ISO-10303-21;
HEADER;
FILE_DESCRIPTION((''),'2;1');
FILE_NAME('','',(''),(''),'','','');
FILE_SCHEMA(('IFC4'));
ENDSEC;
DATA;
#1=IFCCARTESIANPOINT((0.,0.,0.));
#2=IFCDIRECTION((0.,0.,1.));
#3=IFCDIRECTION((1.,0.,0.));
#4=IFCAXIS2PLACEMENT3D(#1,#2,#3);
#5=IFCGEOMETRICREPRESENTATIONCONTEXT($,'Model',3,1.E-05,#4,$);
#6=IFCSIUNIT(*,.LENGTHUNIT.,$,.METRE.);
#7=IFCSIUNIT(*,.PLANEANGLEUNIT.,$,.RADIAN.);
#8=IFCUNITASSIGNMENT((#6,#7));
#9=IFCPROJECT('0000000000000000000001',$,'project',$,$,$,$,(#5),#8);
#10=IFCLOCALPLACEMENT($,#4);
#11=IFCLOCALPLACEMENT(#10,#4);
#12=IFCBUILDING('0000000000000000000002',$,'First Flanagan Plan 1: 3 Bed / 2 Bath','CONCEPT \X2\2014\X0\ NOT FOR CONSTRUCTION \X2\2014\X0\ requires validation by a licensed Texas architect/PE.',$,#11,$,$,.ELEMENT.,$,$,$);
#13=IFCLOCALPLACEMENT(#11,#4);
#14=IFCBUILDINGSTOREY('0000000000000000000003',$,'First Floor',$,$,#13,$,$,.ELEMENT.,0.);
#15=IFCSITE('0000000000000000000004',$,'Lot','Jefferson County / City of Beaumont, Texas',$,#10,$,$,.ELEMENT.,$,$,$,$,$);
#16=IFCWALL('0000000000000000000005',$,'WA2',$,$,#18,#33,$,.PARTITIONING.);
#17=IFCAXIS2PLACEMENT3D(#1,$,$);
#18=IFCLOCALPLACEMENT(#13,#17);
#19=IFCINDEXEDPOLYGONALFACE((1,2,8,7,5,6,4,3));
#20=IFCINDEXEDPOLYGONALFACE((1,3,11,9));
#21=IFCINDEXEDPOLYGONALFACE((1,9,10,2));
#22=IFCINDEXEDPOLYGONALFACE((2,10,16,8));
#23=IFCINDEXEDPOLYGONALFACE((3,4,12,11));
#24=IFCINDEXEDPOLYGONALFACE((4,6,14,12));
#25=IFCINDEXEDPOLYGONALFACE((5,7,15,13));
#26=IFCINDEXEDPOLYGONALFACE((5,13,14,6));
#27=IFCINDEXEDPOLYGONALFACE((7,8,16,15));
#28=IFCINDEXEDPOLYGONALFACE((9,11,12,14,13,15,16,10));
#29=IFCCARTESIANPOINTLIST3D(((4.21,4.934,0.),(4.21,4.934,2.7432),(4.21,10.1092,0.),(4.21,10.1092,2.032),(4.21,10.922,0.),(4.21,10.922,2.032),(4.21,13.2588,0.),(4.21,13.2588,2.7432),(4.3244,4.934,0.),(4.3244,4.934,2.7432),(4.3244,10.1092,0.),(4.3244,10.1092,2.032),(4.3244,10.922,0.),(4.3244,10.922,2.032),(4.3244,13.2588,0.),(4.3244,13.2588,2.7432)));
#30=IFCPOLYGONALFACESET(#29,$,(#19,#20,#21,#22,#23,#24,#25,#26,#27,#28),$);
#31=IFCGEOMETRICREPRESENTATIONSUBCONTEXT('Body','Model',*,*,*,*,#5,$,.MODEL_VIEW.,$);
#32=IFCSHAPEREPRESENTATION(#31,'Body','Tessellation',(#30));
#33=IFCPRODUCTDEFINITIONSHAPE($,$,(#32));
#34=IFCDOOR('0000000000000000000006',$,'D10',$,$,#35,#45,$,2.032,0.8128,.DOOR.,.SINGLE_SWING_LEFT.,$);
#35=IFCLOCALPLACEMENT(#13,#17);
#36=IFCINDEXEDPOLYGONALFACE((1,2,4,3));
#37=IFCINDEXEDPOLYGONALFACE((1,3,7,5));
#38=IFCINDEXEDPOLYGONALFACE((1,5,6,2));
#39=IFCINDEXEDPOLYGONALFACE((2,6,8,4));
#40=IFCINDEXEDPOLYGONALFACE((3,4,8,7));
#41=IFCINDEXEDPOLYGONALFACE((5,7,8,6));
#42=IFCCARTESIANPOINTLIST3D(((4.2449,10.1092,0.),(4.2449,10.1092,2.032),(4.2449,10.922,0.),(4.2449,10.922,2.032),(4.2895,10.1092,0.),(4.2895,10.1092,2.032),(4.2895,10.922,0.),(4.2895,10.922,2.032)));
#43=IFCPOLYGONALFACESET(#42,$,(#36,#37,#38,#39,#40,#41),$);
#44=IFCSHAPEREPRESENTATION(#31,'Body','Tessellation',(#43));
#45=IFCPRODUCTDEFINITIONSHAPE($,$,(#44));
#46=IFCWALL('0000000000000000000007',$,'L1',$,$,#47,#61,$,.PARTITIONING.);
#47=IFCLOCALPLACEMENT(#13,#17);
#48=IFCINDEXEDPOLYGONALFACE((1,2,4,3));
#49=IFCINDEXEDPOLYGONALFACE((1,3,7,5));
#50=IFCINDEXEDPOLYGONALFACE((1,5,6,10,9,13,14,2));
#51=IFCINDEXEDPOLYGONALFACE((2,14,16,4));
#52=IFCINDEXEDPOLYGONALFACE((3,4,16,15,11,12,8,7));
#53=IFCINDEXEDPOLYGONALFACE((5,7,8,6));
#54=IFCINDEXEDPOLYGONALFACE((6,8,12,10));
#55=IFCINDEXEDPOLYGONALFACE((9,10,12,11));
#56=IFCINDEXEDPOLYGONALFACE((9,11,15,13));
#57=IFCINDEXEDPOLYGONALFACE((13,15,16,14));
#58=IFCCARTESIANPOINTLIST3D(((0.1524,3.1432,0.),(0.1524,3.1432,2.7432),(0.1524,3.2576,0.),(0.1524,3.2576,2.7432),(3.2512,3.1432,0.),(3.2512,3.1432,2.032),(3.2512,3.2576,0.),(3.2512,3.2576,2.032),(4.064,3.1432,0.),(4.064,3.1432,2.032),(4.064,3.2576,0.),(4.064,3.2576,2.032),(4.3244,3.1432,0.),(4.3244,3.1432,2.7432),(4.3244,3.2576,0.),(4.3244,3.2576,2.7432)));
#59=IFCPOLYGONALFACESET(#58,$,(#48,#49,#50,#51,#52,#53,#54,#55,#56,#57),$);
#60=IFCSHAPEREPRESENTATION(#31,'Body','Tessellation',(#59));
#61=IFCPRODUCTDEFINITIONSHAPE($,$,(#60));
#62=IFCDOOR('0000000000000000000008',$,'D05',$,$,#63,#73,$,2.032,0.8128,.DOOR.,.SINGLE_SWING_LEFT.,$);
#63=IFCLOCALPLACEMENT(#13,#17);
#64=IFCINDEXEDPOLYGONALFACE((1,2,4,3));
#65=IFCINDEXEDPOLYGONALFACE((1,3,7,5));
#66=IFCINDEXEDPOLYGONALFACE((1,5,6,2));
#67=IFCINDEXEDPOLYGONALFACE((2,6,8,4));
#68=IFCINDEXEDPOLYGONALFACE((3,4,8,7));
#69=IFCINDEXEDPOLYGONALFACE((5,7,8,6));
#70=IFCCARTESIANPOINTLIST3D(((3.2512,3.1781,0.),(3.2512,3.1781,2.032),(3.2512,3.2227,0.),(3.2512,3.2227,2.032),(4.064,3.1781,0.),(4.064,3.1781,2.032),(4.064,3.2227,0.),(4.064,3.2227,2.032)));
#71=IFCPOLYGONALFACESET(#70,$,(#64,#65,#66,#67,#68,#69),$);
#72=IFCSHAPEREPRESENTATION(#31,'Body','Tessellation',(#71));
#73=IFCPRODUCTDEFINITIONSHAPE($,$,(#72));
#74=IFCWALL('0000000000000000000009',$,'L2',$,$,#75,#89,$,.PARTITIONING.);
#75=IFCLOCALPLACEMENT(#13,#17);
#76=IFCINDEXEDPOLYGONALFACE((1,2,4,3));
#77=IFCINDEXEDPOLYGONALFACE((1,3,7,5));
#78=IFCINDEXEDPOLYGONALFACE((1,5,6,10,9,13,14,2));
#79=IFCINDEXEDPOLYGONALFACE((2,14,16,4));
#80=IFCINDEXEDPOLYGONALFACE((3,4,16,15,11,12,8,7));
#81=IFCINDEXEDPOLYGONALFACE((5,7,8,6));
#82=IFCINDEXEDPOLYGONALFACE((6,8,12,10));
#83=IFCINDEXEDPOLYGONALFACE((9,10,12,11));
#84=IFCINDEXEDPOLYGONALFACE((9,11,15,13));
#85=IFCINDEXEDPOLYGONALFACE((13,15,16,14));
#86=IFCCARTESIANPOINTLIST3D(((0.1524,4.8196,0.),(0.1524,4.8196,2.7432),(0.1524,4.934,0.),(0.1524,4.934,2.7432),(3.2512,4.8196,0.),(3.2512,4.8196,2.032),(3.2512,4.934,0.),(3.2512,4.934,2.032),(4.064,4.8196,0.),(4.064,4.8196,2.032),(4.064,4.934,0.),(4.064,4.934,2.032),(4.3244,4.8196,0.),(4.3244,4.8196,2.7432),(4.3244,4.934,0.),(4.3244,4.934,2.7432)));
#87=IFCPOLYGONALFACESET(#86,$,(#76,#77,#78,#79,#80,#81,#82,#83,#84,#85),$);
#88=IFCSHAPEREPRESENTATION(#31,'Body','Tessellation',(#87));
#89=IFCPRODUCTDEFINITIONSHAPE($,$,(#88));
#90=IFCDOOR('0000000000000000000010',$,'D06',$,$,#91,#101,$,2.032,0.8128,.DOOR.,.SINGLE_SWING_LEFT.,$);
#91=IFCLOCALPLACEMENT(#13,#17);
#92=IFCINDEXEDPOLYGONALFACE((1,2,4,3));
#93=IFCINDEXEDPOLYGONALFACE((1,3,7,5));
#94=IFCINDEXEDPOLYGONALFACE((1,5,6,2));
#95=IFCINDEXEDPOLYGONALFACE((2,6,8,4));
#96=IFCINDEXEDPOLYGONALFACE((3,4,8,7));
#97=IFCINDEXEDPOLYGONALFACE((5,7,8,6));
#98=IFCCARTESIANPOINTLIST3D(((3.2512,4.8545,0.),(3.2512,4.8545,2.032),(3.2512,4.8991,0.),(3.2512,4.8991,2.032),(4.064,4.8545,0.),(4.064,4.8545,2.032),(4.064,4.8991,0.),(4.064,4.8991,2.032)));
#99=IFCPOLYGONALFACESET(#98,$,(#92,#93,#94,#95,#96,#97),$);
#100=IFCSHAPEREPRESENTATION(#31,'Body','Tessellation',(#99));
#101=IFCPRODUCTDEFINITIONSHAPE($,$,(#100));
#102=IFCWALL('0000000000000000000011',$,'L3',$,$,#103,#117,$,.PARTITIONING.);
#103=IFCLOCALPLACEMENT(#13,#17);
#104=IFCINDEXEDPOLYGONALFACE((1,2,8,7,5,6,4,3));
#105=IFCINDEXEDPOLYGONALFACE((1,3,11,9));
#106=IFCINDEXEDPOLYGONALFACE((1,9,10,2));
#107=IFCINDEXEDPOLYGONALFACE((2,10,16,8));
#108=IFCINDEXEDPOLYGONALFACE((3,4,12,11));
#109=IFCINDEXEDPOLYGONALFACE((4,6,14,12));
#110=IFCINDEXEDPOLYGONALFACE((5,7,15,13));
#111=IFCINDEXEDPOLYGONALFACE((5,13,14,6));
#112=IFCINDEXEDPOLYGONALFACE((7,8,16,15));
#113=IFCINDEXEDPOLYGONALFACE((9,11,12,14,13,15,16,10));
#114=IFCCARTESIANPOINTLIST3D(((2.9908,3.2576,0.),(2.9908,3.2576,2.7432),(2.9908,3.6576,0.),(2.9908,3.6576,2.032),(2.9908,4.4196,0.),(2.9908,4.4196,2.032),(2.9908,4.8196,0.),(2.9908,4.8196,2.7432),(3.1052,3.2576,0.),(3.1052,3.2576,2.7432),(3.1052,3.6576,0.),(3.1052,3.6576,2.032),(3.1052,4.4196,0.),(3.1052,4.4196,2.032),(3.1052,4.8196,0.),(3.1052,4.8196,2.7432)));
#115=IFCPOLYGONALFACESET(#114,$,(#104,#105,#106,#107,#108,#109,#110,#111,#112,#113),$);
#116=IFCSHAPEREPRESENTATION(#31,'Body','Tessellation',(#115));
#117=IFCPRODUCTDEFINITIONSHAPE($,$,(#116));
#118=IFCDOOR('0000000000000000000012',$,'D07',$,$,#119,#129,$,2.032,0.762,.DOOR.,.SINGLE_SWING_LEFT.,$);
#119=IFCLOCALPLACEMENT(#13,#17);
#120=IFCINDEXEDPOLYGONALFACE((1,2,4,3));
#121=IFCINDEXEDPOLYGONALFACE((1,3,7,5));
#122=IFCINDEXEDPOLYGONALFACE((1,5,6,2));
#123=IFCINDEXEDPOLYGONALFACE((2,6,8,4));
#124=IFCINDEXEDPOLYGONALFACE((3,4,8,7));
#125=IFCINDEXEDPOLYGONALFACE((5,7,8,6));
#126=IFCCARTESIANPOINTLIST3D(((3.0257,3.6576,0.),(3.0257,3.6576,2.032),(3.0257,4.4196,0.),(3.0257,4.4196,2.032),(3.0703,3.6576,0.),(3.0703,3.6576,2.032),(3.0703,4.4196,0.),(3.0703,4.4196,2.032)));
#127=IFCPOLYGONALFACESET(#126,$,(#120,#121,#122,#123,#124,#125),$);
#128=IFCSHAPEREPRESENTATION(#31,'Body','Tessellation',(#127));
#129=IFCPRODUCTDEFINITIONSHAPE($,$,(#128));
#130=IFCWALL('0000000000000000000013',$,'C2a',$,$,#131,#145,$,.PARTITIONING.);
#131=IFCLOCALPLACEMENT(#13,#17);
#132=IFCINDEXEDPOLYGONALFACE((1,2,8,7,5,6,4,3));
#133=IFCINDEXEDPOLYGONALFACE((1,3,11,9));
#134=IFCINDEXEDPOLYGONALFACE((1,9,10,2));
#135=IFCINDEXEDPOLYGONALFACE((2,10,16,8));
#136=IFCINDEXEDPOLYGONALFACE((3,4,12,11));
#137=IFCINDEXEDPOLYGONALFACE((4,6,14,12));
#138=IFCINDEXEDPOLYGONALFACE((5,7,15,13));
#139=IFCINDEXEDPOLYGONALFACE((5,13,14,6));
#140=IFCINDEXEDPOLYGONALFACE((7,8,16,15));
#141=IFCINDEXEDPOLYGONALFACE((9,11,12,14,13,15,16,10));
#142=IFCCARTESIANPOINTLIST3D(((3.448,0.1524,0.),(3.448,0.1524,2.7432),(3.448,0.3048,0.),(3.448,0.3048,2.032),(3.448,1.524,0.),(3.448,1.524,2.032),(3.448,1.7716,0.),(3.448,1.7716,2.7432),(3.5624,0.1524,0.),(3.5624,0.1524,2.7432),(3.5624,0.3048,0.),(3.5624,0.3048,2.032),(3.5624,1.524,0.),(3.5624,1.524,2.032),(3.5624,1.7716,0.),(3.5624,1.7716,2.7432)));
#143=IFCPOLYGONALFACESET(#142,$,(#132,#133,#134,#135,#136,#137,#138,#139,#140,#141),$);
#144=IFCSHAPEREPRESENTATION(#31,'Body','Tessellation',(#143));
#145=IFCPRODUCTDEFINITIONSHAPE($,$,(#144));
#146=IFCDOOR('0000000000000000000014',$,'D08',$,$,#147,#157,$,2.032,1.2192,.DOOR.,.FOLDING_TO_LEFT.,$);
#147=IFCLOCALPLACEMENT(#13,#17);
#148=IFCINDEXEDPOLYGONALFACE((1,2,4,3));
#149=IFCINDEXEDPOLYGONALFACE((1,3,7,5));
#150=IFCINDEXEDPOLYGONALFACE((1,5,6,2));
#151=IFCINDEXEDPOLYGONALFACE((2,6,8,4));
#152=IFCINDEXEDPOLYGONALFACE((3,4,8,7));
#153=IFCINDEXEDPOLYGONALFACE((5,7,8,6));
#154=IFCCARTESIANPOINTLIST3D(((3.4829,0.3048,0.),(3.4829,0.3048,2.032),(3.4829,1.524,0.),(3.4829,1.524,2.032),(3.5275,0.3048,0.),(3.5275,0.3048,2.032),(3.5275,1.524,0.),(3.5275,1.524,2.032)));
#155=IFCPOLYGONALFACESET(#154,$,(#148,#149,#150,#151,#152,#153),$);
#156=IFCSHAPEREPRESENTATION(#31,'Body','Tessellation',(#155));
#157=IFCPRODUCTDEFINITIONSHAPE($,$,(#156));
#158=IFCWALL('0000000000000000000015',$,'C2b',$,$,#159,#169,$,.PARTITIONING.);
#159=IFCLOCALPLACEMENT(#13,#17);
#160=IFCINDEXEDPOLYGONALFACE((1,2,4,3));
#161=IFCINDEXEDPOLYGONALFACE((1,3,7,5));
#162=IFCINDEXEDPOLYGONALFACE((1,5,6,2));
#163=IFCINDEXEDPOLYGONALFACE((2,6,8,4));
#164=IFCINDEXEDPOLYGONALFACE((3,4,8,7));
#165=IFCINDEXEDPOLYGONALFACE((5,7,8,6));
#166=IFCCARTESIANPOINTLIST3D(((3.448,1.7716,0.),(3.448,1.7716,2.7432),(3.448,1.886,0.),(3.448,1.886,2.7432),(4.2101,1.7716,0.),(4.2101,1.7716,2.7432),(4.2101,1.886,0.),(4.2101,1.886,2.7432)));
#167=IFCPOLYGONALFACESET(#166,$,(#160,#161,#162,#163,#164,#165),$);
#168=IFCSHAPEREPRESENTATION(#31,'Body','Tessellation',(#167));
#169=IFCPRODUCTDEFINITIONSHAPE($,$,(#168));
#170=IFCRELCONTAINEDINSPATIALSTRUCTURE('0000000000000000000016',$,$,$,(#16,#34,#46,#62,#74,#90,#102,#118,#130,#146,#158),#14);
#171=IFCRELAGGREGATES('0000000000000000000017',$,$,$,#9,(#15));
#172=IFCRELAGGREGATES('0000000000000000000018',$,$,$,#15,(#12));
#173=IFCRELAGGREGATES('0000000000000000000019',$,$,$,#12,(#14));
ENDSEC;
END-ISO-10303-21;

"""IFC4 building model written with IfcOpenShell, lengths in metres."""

from ifc_helpers import new_model, si_unit, frame, frame_2d, origin_with_axes, place, context, subcontext, project, spatial, rectangle, extrude, element, fill, save


model = new_model("IFC4")

# Units and contexts
model_context = context("Model", 3, precision=1e-05, world=origin_with_axes())
body_context = subcontext(model_context, "Body", "Model", "MODEL_VIEW")
ifc_project = project(units=[si_unit("LENGTHUNIT", "METRE"), si_unit("PLANEANGLEUNIT", "RADIAN")], contexts=[model_context])

# Site, building, storey
site_placement = place(None, origin_with_axes())
site = spatial("IfcSite", under=ifc_project, at=site_placement, Name="Lot", Description="Jefferson County / City of Beaumont, Texas", CompositionType="ELEMENT")
building_placement = place(site_placement, origin_with_axes())
building = spatial("IfcBuilding", under=site, at=building_placement, Name="First Flanagan Plan 1: 3 Bed / 2 Bath", Description="CONCEPT — NOT FOR CONSTRUCTION — requires validation by a licensed Texas architect/PE.", CompositionType="ELEMENT")
storey_placement = place(building_placement, origin_with_axes())
storey = spatial("IfcBuildingStorey", under=building, at=storey_placement, Name="First Floor", CompositionType="ELEMENT", Elevation=0.0)

# Walls, openings, doors
wall_1_placement = place(storey_placement, frame((4.2672, 4.934, 0.0), z_axis=(0.0, 0.0, 1.0), x_axis=(0.0, 1.0, 0.0)))
wall_1 = element("IfcWall", 1, at=wall_1_placement, inside=storey, Name="WA2", PredefinedType="PARTITIONING", context=body_context, shape_type="SweptSolid", body=[
    extrude(rectangle(XDim=8.3248, YDim=0.1143, at=frame_2d((4.1624, 0.0), x_axis=(1.0, 0.0))), origin_with_axes(), (0.0, 0.0, 1.0), 2.7432),
])
opening_1_placement = place(wall_1_placement, frame((5.1752, 0.0, 0.0), z_axis=(0.0, 0.0, 1.0), x_axis=(1.0, 0.0, 0.0)))
opening_1 = element("IfcOpeningElement", 2, at=opening_1_placement, cuts=wall_1, PredefinedType="OPENING", context=body_context, shape_type="SweptSolid", body=[
    extrude(rectangle(XDim=0.8128, YDim=0.1448, at=frame_2d((0.4064, 0.0), x_axis=(1.0, 0.0))), origin_with_axes(), (0.0, 0.0, 1.0), 2.032),
])
door_1_placement = place(opening_1_placement, origin_with_axes())
door_1 = element("IfcDoor", 3, at=door_1_placement, inside=storey, Name="D10", OperationType="SINGLE_SWING_LEFT", OverallHeight=2.032, OverallWidth=0.8128, PredefinedType="DOOR", context=body_context, shape_type="SweptSolid", body=[
    extrude(rectangle(XDim=0.8128, YDim=0.0445, at=frame_2d((0.4064, 0.0), x_axis=(1.0, 0.0))), origin_with_axes(), (0.0, 0.0, 1.0), 2.032),
])
fill(opening_1, door_1)
wall_2_placement = place(storey_placement, frame((0.1524, 3.2004, 0.0), z_axis=(0.0, 0.0, 1.0), x_axis=(1.0, 0.0, 0.0)))
wall_2 = element("IfcWall", 4, at=wall_2_placement, inside=storey, Name="L1", PredefinedType="PARTITIONING", context=body_context, shape_type="SweptSolid", body=[
    extrude(rectangle(XDim=4.1719, YDim=0.1143, at=frame_2d((2.086, 0.0), x_axis=(1.0, 0.0))), origin_with_axes(), (0.0, 0.0, 1.0), 2.7432),
])
opening_2_placement = place(wall_2_placement, frame((3.0988, 0.0, 0.0), z_axis=(0.0, 0.0, 1.0), x_axis=(1.0, 0.0, 0.0)))
opening_2 = element("IfcOpeningElement", 5, at=opening_2_placement, cuts=wall_2, PredefinedType="OPENING", context=body_context, shape_type="SweptSolid", body=[
    extrude(rectangle(XDim=0.8128, YDim=0.1448, at=frame_2d((0.4064, 0.0), x_axis=(1.0, 0.0))), origin_with_axes(), (0.0, 0.0, 1.0), 2.032),
])
door_2_placement = place(opening_2_placement, origin_with_axes())
door_2 = element("IfcDoor", 6, at=door_2_placement, inside=storey, Name="D05", OperationType="SINGLE_SWING_LEFT", OverallHeight=2.032, OverallWidth=0.8128, PredefinedType="DOOR", context=body_context, shape_type="SweptSolid", body=[
    extrude(rectangle(XDim=0.8128, YDim=0.0445, at=frame_2d((0.4064, 0.0), x_axis=(1.0, 0.0))), origin_with_axes(), (0.0, 0.0, 1.0), 2.032),
])
fill(opening_2, door_2)
wall_3_placement = place(storey_placement, frame((0.1524, 4.8768, 0.0), z_axis=(0.0, 0.0, 1.0), x_axis=(1.0, 0.0, 0.0)))
wall_3 = element("IfcWall", 7, at=wall_3_placement, inside=storey, Name="L2", PredefinedType="PARTITIONING", context=body_context, shape_type="SweptSolid", body=[
    extrude(rectangle(XDim=4.1719, YDim=0.1143, at=frame_2d((2.086, 0.0), x_axis=(1.0, 0.0))), origin_with_axes(), (0.0, 0.0, 1.0), 2.7432),
])
opening_3_placement = place(wall_3_placement, frame((3.0988, 0.0, 0.0), z_axis=(0.0, 0.0, 1.0), x_axis=(1.0, 0.0, 0.0)))
opening_3 = element("IfcOpeningElement", 8, at=opening_3_placement, cuts=wall_3, PredefinedType="OPENING", context=body_context, shape_type="SweptSolid", body=[
    extrude(rectangle(XDim=0.8128, YDim=0.1448, at=frame_2d((0.4064, 0.0), x_axis=(1.0, 0.0))), origin_with_axes(), (0.0, 0.0, 1.0), 2.032),
])
door_3_placement = place(opening_3_placement, origin_with_axes())
door_3 = element("IfcDoor", 9, at=door_3_placement, inside=storey, Name="D06", OperationType="SINGLE_SWING_LEFT", OverallHeight=2.032, OverallWidth=0.8128, PredefinedType="DOOR", context=body_context, shape_type="SweptSolid", body=[
    extrude(rectangle(XDim=0.8128, YDim=0.0445, at=frame_2d((0.4064, 0.0), x_axis=(1.0, 0.0))), origin_with_axes(), (0.0, 0.0, 1.0), 2.032),
])
fill(opening_3, door_3)
wall_4_placement = place(storey_placement, frame((3.048, 3.2576, 0.0), z_axis=(0.0, 0.0, 1.0), x_axis=(0.0, 1.0, 0.0)))
wall_4 = element("IfcWall", 10, at=wall_4_placement, inside=storey, Name="L3", PredefinedType="PARTITIONING", context=body_context, shape_type="SweptSolid", body=[
    extrude(rectangle(XDim=1.5621, YDim=0.1143, at=frame_2d((0.7811, 0.0), x_axis=(1.0, 0.0))), origin_with_axes(), (0.0, 0.0, 1.0), 2.7432),
])
opening_4_placement = place(wall_4_placement, frame((0.4001, 0.0, 0.0), z_axis=(0.0, 0.0, 1.0), x_axis=(1.0, 0.0, 0.0)))
opening_4 = element("IfcOpeningElement", 11, at=opening_4_placement, cuts=wall_4, PredefinedType="OPENING", context=body_context, shape_type="SweptSolid", body=[
    extrude(rectangle(XDim=0.762, YDim=0.1448, at=frame_2d((0.381, 0.0), x_axis=(1.0, 0.0))), origin_with_axes(), (0.0, 0.0, 1.0), 2.032),
])
door_4_placement = place(opening_4_placement, origin_with_axes())
door_4 = element("IfcDoor", 12, at=door_4_placement, inside=storey, Name="D07", OperationType="SINGLE_SWING_LEFT", OverallHeight=2.032, OverallWidth=0.762, PredefinedType="DOOR", context=body_context, shape_type="SweptSolid", body=[
    extrude(rectangle(XDim=0.762, YDim=0.0445, at=frame_2d((0.381, 0.0), x_axis=(1.0, 0.0))), origin_with_axes(), (0.0, 0.0, 1.0), 2.032),
])
fill(opening_4, door_4)
wall_5_placement = place(storey_placement, frame((3.5052, 0.1524, 0.0), z_axis=(0.0, 0.0, 1.0), x_axis=(0.0, 1.0, 0.0)))
wall_5 = element("IfcWall", 13, at=wall_5_placement, inside=storey, Name="C2a", PredefinedType="PARTITIONING", context=body_context, shape_type="SweptSolid", body=[
    extrude(rectangle(XDim=1.6193, YDim=0.1143, at=frame_2d((0.8096, 0.0), x_axis=(1.0, 0.0))), origin_with_axes(), (0.0, 0.0, 1.0), 2.7432),
])
opening_5_placement = place(wall_5_placement, frame((0.1524, 0.0, 0.0), z_axis=(0.0, 0.0, 1.0), x_axis=(1.0, 0.0, 0.0)))
opening_5 = element("IfcOpeningElement", 14, at=opening_5_placement, cuts=wall_5, PredefinedType="OPENING", context=body_context, shape_type="SweptSolid", body=[
    extrude(rectangle(XDim=1.2192, YDim=0.1448, at=frame_2d((0.6096, 0.0), x_axis=(1.0, 0.0))), origin_with_axes(), (0.0, 0.0, 1.0), 2.032),
])
door_5_placement = place(opening_5_placement, origin_with_axes())
door_5 = element("IfcDoor", 15, at=door_5_placement, inside=storey, Name="D08", OperationType="FOLDING_TO_LEFT", OverallHeight=2.032, OverallWidth=1.2192, PredefinedType="DOOR", context=body_context, shape_type="SweptSolid", body=[
    extrude(rectangle(XDim=1.2192, YDim=0.0445, at=frame_2d((0.6096, 0.0), x_axis=(1.0, 0.0))), origin_with_axes(), (0.0, 0.0, 1.0), 2.032),
])
fill(opening_5, door_5)

# Wall
wall_6_placement = place(storey_placement, frame((3.4481, 1.8288, 0.0), z_axis=(0.0, 0.0, 1.0), x_axis=(1.0, 0.0, 0.0)))
element("IfcWall", 16, at=wall_6_placement, inside=storey, Name="C2b", PredefinedType="PARTITIONING", context=body_context, shape_type="SweptSolid", body=[
    extrude(rectangle(XDim=0.762, YDim=0.1143, at=frame_2d((0.381, 0.0), x_axis=(1.0, 0.0))), origin_with_axes(), (0.0, 0.0, 1.0), 2.7432),
])

save(model, "model.ifc")
